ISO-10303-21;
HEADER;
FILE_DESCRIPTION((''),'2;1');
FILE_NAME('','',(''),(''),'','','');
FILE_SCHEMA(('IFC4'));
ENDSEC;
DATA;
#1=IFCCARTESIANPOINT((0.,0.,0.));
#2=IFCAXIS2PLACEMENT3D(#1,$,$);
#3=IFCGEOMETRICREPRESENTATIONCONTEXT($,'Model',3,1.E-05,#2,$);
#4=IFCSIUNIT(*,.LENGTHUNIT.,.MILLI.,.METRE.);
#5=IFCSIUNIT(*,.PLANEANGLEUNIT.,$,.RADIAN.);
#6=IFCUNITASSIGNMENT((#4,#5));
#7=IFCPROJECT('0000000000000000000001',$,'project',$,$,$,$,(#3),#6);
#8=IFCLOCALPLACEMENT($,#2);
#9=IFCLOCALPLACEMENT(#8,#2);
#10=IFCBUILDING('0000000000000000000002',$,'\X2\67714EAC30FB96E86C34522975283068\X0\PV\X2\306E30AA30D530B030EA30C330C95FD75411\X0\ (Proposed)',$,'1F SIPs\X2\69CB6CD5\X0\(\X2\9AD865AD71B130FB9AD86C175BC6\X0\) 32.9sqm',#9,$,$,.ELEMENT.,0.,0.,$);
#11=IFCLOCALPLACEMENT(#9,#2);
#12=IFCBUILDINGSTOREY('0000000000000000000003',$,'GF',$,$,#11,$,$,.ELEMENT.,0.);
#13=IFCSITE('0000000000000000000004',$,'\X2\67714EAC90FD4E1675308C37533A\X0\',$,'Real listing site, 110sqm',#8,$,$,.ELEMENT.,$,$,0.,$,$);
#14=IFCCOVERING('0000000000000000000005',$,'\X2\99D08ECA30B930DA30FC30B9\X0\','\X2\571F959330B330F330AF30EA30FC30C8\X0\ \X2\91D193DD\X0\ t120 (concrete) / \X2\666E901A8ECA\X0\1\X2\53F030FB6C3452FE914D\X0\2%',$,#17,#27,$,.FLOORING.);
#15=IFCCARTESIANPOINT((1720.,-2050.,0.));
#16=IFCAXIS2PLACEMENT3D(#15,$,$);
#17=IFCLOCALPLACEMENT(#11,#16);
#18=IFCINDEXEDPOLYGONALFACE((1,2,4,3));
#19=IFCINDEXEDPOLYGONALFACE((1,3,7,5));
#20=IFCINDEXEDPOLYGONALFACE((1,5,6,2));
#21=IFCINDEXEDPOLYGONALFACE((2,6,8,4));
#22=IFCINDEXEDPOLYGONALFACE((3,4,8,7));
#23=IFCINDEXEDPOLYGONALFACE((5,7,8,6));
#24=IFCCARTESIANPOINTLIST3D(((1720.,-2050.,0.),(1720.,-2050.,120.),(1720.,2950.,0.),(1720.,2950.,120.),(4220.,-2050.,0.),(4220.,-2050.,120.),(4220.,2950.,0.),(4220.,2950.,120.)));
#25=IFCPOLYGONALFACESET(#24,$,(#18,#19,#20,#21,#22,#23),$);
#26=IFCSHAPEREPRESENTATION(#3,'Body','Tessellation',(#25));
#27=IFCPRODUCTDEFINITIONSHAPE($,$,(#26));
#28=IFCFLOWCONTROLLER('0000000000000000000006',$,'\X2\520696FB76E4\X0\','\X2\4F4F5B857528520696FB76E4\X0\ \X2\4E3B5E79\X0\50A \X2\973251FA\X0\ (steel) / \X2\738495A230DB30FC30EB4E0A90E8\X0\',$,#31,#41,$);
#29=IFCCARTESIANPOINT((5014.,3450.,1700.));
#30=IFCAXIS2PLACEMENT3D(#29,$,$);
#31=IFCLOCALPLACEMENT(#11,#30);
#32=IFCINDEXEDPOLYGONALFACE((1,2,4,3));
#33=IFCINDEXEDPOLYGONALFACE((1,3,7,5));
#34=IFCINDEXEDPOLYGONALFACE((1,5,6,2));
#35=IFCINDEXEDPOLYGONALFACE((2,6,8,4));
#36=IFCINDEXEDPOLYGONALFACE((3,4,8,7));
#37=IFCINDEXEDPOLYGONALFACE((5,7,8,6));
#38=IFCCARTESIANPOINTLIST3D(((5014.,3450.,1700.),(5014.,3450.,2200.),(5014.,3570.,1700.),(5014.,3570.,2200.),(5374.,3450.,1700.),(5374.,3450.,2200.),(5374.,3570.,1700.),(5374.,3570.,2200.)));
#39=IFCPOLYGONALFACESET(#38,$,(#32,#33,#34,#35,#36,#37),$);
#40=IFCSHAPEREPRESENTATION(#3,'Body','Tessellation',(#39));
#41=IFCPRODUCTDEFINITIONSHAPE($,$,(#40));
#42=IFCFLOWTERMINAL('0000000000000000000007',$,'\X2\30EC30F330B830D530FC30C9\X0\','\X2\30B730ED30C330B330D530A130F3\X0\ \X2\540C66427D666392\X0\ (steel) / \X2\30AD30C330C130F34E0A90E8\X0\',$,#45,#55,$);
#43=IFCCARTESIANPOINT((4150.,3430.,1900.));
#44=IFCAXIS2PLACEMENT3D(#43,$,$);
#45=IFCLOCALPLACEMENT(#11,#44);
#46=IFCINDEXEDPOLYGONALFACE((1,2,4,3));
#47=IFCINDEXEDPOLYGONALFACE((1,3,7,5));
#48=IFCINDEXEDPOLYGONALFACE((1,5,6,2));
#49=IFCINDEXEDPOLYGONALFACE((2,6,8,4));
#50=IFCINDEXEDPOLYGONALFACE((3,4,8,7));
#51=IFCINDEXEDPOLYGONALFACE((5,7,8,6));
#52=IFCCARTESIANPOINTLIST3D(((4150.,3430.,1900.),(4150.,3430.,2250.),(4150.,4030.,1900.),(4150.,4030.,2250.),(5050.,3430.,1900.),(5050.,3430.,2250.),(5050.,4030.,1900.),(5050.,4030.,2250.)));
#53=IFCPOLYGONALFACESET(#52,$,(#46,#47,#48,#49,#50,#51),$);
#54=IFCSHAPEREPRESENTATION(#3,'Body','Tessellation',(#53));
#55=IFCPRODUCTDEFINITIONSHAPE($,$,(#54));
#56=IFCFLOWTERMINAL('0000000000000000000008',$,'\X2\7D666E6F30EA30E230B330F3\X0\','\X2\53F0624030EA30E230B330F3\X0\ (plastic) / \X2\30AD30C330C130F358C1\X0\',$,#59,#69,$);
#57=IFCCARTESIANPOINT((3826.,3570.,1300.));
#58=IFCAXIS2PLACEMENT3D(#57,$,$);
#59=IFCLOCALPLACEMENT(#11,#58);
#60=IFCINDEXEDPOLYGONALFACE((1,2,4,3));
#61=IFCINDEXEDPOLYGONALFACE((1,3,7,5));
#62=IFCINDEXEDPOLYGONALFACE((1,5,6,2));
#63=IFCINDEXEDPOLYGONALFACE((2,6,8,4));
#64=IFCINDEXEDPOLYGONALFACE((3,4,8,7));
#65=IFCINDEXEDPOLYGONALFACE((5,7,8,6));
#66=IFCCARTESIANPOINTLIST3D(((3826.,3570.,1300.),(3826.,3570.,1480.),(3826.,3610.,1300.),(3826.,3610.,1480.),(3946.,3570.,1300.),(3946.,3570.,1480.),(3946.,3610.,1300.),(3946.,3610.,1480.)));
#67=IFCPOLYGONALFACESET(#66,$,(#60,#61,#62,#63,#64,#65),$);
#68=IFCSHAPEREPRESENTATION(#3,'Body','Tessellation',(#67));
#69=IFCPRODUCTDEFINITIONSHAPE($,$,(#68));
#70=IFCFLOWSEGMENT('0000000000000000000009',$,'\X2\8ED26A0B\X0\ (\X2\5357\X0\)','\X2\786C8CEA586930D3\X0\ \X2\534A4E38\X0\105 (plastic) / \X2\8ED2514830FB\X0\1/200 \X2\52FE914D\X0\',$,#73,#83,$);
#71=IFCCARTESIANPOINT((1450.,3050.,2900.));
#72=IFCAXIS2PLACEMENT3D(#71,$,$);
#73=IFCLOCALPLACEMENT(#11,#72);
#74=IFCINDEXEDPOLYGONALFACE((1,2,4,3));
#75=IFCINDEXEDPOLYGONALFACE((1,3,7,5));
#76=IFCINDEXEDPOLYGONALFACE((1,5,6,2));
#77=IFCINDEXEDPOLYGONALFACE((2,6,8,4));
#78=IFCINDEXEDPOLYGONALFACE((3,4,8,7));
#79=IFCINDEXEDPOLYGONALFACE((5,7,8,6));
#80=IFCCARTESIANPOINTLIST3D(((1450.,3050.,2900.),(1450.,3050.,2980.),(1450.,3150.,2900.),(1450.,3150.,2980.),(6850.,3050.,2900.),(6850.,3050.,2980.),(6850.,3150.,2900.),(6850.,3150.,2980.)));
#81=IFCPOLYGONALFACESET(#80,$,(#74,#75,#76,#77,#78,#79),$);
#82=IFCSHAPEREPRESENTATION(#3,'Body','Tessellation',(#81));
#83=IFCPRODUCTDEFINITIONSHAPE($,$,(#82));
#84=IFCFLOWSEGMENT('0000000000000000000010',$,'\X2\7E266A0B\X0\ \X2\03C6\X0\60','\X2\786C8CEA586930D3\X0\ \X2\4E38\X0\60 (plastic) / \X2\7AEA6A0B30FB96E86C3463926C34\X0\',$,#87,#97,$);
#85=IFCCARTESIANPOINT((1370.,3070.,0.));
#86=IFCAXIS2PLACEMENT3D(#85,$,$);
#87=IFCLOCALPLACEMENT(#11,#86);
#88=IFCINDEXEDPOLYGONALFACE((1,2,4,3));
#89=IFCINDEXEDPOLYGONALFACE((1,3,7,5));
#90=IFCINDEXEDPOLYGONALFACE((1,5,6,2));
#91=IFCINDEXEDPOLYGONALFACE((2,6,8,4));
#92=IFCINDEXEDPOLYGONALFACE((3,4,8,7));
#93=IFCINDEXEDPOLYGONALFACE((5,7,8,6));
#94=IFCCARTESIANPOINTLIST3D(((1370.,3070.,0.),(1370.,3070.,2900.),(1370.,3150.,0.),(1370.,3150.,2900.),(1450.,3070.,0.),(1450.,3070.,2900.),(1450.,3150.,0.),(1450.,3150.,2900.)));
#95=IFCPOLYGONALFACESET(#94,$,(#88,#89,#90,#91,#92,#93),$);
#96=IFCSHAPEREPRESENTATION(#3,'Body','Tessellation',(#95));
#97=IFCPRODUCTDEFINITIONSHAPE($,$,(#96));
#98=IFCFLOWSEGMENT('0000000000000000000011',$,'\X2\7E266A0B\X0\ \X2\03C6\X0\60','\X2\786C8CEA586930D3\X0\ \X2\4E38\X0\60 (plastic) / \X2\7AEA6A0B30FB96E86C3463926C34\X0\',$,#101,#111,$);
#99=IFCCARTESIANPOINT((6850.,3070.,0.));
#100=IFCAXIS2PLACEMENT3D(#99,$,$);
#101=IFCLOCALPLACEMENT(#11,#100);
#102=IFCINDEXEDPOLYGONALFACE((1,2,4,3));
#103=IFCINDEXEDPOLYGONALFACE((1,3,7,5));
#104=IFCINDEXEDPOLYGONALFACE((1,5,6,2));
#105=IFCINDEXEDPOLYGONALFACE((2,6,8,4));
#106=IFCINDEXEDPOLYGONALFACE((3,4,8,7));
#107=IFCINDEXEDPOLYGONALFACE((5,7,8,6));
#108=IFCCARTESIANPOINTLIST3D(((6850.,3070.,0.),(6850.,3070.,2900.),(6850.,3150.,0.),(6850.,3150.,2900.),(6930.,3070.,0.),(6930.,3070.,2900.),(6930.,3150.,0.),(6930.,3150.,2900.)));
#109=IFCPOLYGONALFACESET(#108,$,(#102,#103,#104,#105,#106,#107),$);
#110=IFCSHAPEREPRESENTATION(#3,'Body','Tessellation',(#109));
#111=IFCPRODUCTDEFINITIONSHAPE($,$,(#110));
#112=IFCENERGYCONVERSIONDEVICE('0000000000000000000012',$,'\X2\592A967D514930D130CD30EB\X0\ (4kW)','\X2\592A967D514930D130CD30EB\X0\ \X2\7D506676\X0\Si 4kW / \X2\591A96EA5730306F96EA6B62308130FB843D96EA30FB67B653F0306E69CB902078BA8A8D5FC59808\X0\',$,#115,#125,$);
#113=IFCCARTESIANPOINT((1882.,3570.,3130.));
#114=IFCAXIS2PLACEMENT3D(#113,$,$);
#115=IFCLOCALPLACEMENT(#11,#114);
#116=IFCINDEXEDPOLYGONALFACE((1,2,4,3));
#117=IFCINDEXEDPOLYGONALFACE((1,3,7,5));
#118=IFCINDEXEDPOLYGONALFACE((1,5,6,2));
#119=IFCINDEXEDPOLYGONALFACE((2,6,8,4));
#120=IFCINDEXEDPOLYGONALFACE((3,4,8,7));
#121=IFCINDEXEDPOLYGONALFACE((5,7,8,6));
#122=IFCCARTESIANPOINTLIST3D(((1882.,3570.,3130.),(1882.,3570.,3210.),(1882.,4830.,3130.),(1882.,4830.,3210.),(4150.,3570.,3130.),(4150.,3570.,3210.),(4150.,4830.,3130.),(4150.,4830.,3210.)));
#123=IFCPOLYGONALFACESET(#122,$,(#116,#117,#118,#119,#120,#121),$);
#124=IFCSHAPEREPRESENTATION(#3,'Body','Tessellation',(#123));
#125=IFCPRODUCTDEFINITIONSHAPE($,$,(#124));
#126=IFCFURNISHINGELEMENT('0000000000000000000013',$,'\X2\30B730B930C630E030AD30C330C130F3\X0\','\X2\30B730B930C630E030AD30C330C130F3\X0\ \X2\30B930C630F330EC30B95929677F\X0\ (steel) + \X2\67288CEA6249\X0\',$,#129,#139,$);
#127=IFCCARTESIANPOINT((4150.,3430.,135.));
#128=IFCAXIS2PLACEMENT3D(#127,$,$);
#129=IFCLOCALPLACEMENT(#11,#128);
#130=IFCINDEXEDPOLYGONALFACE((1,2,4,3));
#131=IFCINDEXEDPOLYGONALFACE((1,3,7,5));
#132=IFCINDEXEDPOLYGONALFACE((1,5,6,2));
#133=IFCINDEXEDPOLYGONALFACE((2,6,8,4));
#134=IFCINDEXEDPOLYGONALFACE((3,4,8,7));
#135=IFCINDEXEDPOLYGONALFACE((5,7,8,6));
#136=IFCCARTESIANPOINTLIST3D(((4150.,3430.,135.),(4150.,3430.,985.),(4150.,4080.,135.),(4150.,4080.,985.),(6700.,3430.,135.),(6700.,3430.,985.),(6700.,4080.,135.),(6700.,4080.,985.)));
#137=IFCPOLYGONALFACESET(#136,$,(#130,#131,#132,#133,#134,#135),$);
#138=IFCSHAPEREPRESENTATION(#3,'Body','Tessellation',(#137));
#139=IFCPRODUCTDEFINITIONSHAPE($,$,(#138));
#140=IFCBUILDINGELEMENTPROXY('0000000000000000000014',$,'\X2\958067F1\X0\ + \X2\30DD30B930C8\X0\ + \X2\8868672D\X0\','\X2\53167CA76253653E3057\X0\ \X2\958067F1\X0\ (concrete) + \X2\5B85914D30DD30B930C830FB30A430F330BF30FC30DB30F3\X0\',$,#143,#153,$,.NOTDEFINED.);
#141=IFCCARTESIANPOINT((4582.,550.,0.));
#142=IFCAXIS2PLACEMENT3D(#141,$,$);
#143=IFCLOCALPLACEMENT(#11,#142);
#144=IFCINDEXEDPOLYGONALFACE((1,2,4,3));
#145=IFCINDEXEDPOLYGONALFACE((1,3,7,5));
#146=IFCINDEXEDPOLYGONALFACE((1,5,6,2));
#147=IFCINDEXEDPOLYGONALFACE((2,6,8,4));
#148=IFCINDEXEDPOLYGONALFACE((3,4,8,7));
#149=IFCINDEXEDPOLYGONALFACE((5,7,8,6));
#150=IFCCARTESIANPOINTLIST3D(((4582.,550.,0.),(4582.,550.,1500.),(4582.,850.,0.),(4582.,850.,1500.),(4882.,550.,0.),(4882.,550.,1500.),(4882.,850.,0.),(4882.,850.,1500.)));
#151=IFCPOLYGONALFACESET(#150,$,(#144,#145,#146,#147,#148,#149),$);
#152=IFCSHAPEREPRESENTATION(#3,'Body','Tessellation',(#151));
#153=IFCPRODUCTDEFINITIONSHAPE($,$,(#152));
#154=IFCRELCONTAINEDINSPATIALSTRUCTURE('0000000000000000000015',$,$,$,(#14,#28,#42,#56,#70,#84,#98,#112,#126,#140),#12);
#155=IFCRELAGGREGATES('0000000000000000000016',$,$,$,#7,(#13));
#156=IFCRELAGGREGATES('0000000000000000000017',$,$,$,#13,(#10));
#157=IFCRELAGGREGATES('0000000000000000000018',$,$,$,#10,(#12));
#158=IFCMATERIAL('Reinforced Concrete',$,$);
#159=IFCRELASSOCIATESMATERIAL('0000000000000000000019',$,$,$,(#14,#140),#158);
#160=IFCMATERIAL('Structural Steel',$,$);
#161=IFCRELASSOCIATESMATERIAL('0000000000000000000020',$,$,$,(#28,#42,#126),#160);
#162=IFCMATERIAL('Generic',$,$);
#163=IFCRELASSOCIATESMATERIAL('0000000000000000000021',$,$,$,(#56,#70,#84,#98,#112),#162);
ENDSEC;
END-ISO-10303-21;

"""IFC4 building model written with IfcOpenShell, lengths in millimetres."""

from ifc_helpers import new_model, si_unit, frame, frame_2d, origin, place, context, project, spatial, rectangle, extrude, material, element, save


model = new_model("IFC4")

# Units and contexts
model_context = context("Model", 3, precision=1e-05, world=origin())
ifc_project = project(units=[si_unit("LENGTHUNIT", "METRE", prefix="MILLI"), si_unit("PLANEANGLEUNIT", "RADIAN")], contexts=[model_context])

# Site, building, storey
site_placement = place(None, origin())
site = spatial("IfcSite", under=ifc_project, at=site_placement, Name="東京都世田谷区", ObjectType="Real listing site, 110sqm", CompositionType="ELEMENT", RefElevation=0.0)
building_placement = place(site_placement, origin())
building = spatial("IfcBuilding", under=site, at=building_placement, Name="東京・雨水利用とPVのオフグリッド志向 (Proposed)", ObjectType="1F SIPs構法(高断熱・高気密) 32.9sqm", CompositionType="ELEMENT", ElevationOfRefHeight=0.0, ElevationOfTerrain=0.0)
storey_placement = place(building_placement, origin())
storey = spatial("IfcBuildingStorey", under=building, at=storey_placement, Name="GF", CompositionType="ELEMENT", Elevation=0.0)

# Shared definitions
ifc_material_1 = material(Name="Reinforced Concrete")

# Shared definitions
ifc_material_2 = material(Name="Structural Steel")

# Covering
ifc_material_3 = material(Name="Generic")
covering_1_placement = place(storey_placement, frame((1720.0, -2050.0, 0.0)))
element("IfcCovering", 1, at=covering_1_placement, inside=storey, material=ifc_material_1, Name="駐車スペース", Description="土間コンクリート 金鏝 t120 (concrete) / 普通車1台・水勾配2%", PredefinedType="FLOORING", context=model_context, shape_type="SweptSolid", body=[
    extrude(rectangle(XDim=2500.0, YDim=5000.0, at=frame_2d((1250.0, 2500.0))), frame((1720.0, -2050.0, 0.0)), (0.0, 0.0, 1.0), 120.0),
])

# Flow controller
flow_controller_placement = place(storey_placement, frame((5014.0, 3450.0, 1700.0)))
element("IfcFlowController", 2, at=flow_controller_placement, inside=storey, material=ifc_material_2, Name="分電盤", Description="住宅用分電盤 主幹50A 露出 (steel) / 玄関ホール上部", context=model_context, shape_type="SweptSolid", body=[
    extrude(rectangle(XDim=360.0, YDim=120.0, at=frame_2d((180.0, 60.0))), frame((5014.0, 3450.0, 1700.0)), (0.0, 0.0, 1.0), 500.0),
])

# Flow terminals
flow_terminal_1_placement = place(storey_placement, frame((4150.0, 3430.0, 1900.0)))
element("IfcFlowTerminal", 3, at=flow_terminal_1_placement, inside=storey, material=ifc_material_2, Name="レンジフード", Description="シロッコファン 同時給排 (steel) / キッチン上部", context=model_context, shape_type="SweptSolid", body=[
    extrude(rectangle(XDim=900.0, YDim=600.0, at=frame_2d((450.0, 300.0))), frame((4150.0, 3430.0, 1900.0)), (0.0, 0.0, 1.0), 350.0),
])
flow_terminal_2_placement = place(storey_placement, frame((3826.0, 3570.0, 1300.0)))
element("IfcFlowTerminal", 4, at=flow_terminal_2_placement, inside=storey, material=ifc_material_3, Name="給湯リモコン", Description="台所リモコン (plastic) / キッチン壁", context=model_context, shape_type="SweptSolid", body=[
    extrude(rectangle(XDim=120.0, YDim=40.0, at=frame_2d((60.0, 20.0))), frame((3826.0, 3570.0, 1300.0)), (0.0, 0.0, 1.0), 180.0),
])

# Flow segments
flow_segment_1_placement = place(storey_placement, frame((1450.0, 3050.0, 2900.0)))
element("IfcFlowSegment", 5, at=flow_segment_1_placement, inside=storey, material=ifc_material_3, Name="軒樋 (南)", Description="硬質塩ビ 半丸105 (plastic) / 軒先・1/200 勾配", context=model_context, shape_type="SweptSolid", body=[
    extrude(rectangle(XDim=5400.0, YDim=100.0, at=frame_2d((2700.0, 50.0))), frame((1450.0, 3050.0, 2900.0)), (0.0, 0.0, 1.0), 80.0),
])
flow_segment_2_placement = place(storey_placement, frame((1370.0, 3070.0, 0.0)))
element("IfcFlowSegment", 6, at=flow_segment_2_placement, inside=storey, material=ifc_material_3, Name="縦樋 φ60", Description="硬質塩ビ 丸60 (plastic) / 竪樋・雨水排水", context=model_context, shape_type="SweptSolid", body=[
    extrude(rectangle(XDim=80.0, YDim=80.0, at=frame_2d((40.0, 40.0))), frame((1370.0, 3070.0, 0.0)), (0.0, 0.0, 1.0), 2900.0),
])
flow_segment_3_placement = place(storey_placement, frame((6850.0, 3070.0, 0.0)))
element("IfcFlowSegment", 7, at=flow_segment_3_placement, inside=storey, material=ifc_material_3, Name="縦樋 φ60", Description="硬質塩ビ 丸60 (plastic) / 竪樋・雨水排水", context=model_context, shape_type="SweptSolid", body=[
    extrude(rectangle(XDim=80.0, YDim=80.0, at=frame_2d((40.0, 40.0))), frame((6850.0, 3070.0, 0.0)), (0.0, 0.0, 1.0), 2900.0),
])

# Energy conversion device
energy_conversion_device_placement = place(storey_placement, frame((1882.0, 3570.0, 3130.0)))
element("IfcEnergyConversionDevice", 8, at=energy_conversion_device_placement, inside=storey, material=ifc_material_3, Name="太陽光パネル (4kW)", Description="太陽光パネル 結晶Si 4kW / 多雪地は雪止め・落雪・架台の構造確認必須", context=model_context, shape_type="SweptSolid", body=[
    extrude(rectangle(XDim=2268.0, YDim=1260.0, at=frame_2d((1134.0, 630.0))), frame((1882.0, 3570.0, 3130.0)), (0.0, 0.0, 1.0), 80.0),
])

# Furnishing element
furnishing_placement = place(storey_placement, frame((4150.0, 3430.0, 135.0)))
element("IfcFurnishingElement", 9, at=furnishing_placement, inside=storey, material=ifc_material_2, Name="システムキッチン", Description="システムキッチン ステンレス天板 (steel) + 木質扉", context=model_context, shape_type="SweptSolid", body=[
    extrude(rectangle(XDim=2550.0, YDim=650.0, at=frame_2d((1275.0, 325.0))), frame((4150.0, 3430.0, 135.0)), (0.0, 0.0, 1.0), 850.0),
])

# Building element proxy
proxy_placement = place(storey_placement, frame((4582.0, 550.0, 0.0)))
element("IfcBuildingElementProxy", 10, at=proxy_placement, inside=storey, material=ifc_material_1, Name="門柱 + ポスト + 表札", Description="化粧打放し 門柱 (concrete) + 宅配ポスト・インターホン", PredefinedType="NOTDEFINED", context=model_context, shape_type="SweptSolid", body=[
    extrude(rectangle(XDim=300.0, YDim=300.0, at=frame_2d((150.0, 150.0))), frame((4582.0, 550.0, 0.0)), (0.0, 0.0, 1.0), 1500.0),
])

save(model, "model.ifc")
